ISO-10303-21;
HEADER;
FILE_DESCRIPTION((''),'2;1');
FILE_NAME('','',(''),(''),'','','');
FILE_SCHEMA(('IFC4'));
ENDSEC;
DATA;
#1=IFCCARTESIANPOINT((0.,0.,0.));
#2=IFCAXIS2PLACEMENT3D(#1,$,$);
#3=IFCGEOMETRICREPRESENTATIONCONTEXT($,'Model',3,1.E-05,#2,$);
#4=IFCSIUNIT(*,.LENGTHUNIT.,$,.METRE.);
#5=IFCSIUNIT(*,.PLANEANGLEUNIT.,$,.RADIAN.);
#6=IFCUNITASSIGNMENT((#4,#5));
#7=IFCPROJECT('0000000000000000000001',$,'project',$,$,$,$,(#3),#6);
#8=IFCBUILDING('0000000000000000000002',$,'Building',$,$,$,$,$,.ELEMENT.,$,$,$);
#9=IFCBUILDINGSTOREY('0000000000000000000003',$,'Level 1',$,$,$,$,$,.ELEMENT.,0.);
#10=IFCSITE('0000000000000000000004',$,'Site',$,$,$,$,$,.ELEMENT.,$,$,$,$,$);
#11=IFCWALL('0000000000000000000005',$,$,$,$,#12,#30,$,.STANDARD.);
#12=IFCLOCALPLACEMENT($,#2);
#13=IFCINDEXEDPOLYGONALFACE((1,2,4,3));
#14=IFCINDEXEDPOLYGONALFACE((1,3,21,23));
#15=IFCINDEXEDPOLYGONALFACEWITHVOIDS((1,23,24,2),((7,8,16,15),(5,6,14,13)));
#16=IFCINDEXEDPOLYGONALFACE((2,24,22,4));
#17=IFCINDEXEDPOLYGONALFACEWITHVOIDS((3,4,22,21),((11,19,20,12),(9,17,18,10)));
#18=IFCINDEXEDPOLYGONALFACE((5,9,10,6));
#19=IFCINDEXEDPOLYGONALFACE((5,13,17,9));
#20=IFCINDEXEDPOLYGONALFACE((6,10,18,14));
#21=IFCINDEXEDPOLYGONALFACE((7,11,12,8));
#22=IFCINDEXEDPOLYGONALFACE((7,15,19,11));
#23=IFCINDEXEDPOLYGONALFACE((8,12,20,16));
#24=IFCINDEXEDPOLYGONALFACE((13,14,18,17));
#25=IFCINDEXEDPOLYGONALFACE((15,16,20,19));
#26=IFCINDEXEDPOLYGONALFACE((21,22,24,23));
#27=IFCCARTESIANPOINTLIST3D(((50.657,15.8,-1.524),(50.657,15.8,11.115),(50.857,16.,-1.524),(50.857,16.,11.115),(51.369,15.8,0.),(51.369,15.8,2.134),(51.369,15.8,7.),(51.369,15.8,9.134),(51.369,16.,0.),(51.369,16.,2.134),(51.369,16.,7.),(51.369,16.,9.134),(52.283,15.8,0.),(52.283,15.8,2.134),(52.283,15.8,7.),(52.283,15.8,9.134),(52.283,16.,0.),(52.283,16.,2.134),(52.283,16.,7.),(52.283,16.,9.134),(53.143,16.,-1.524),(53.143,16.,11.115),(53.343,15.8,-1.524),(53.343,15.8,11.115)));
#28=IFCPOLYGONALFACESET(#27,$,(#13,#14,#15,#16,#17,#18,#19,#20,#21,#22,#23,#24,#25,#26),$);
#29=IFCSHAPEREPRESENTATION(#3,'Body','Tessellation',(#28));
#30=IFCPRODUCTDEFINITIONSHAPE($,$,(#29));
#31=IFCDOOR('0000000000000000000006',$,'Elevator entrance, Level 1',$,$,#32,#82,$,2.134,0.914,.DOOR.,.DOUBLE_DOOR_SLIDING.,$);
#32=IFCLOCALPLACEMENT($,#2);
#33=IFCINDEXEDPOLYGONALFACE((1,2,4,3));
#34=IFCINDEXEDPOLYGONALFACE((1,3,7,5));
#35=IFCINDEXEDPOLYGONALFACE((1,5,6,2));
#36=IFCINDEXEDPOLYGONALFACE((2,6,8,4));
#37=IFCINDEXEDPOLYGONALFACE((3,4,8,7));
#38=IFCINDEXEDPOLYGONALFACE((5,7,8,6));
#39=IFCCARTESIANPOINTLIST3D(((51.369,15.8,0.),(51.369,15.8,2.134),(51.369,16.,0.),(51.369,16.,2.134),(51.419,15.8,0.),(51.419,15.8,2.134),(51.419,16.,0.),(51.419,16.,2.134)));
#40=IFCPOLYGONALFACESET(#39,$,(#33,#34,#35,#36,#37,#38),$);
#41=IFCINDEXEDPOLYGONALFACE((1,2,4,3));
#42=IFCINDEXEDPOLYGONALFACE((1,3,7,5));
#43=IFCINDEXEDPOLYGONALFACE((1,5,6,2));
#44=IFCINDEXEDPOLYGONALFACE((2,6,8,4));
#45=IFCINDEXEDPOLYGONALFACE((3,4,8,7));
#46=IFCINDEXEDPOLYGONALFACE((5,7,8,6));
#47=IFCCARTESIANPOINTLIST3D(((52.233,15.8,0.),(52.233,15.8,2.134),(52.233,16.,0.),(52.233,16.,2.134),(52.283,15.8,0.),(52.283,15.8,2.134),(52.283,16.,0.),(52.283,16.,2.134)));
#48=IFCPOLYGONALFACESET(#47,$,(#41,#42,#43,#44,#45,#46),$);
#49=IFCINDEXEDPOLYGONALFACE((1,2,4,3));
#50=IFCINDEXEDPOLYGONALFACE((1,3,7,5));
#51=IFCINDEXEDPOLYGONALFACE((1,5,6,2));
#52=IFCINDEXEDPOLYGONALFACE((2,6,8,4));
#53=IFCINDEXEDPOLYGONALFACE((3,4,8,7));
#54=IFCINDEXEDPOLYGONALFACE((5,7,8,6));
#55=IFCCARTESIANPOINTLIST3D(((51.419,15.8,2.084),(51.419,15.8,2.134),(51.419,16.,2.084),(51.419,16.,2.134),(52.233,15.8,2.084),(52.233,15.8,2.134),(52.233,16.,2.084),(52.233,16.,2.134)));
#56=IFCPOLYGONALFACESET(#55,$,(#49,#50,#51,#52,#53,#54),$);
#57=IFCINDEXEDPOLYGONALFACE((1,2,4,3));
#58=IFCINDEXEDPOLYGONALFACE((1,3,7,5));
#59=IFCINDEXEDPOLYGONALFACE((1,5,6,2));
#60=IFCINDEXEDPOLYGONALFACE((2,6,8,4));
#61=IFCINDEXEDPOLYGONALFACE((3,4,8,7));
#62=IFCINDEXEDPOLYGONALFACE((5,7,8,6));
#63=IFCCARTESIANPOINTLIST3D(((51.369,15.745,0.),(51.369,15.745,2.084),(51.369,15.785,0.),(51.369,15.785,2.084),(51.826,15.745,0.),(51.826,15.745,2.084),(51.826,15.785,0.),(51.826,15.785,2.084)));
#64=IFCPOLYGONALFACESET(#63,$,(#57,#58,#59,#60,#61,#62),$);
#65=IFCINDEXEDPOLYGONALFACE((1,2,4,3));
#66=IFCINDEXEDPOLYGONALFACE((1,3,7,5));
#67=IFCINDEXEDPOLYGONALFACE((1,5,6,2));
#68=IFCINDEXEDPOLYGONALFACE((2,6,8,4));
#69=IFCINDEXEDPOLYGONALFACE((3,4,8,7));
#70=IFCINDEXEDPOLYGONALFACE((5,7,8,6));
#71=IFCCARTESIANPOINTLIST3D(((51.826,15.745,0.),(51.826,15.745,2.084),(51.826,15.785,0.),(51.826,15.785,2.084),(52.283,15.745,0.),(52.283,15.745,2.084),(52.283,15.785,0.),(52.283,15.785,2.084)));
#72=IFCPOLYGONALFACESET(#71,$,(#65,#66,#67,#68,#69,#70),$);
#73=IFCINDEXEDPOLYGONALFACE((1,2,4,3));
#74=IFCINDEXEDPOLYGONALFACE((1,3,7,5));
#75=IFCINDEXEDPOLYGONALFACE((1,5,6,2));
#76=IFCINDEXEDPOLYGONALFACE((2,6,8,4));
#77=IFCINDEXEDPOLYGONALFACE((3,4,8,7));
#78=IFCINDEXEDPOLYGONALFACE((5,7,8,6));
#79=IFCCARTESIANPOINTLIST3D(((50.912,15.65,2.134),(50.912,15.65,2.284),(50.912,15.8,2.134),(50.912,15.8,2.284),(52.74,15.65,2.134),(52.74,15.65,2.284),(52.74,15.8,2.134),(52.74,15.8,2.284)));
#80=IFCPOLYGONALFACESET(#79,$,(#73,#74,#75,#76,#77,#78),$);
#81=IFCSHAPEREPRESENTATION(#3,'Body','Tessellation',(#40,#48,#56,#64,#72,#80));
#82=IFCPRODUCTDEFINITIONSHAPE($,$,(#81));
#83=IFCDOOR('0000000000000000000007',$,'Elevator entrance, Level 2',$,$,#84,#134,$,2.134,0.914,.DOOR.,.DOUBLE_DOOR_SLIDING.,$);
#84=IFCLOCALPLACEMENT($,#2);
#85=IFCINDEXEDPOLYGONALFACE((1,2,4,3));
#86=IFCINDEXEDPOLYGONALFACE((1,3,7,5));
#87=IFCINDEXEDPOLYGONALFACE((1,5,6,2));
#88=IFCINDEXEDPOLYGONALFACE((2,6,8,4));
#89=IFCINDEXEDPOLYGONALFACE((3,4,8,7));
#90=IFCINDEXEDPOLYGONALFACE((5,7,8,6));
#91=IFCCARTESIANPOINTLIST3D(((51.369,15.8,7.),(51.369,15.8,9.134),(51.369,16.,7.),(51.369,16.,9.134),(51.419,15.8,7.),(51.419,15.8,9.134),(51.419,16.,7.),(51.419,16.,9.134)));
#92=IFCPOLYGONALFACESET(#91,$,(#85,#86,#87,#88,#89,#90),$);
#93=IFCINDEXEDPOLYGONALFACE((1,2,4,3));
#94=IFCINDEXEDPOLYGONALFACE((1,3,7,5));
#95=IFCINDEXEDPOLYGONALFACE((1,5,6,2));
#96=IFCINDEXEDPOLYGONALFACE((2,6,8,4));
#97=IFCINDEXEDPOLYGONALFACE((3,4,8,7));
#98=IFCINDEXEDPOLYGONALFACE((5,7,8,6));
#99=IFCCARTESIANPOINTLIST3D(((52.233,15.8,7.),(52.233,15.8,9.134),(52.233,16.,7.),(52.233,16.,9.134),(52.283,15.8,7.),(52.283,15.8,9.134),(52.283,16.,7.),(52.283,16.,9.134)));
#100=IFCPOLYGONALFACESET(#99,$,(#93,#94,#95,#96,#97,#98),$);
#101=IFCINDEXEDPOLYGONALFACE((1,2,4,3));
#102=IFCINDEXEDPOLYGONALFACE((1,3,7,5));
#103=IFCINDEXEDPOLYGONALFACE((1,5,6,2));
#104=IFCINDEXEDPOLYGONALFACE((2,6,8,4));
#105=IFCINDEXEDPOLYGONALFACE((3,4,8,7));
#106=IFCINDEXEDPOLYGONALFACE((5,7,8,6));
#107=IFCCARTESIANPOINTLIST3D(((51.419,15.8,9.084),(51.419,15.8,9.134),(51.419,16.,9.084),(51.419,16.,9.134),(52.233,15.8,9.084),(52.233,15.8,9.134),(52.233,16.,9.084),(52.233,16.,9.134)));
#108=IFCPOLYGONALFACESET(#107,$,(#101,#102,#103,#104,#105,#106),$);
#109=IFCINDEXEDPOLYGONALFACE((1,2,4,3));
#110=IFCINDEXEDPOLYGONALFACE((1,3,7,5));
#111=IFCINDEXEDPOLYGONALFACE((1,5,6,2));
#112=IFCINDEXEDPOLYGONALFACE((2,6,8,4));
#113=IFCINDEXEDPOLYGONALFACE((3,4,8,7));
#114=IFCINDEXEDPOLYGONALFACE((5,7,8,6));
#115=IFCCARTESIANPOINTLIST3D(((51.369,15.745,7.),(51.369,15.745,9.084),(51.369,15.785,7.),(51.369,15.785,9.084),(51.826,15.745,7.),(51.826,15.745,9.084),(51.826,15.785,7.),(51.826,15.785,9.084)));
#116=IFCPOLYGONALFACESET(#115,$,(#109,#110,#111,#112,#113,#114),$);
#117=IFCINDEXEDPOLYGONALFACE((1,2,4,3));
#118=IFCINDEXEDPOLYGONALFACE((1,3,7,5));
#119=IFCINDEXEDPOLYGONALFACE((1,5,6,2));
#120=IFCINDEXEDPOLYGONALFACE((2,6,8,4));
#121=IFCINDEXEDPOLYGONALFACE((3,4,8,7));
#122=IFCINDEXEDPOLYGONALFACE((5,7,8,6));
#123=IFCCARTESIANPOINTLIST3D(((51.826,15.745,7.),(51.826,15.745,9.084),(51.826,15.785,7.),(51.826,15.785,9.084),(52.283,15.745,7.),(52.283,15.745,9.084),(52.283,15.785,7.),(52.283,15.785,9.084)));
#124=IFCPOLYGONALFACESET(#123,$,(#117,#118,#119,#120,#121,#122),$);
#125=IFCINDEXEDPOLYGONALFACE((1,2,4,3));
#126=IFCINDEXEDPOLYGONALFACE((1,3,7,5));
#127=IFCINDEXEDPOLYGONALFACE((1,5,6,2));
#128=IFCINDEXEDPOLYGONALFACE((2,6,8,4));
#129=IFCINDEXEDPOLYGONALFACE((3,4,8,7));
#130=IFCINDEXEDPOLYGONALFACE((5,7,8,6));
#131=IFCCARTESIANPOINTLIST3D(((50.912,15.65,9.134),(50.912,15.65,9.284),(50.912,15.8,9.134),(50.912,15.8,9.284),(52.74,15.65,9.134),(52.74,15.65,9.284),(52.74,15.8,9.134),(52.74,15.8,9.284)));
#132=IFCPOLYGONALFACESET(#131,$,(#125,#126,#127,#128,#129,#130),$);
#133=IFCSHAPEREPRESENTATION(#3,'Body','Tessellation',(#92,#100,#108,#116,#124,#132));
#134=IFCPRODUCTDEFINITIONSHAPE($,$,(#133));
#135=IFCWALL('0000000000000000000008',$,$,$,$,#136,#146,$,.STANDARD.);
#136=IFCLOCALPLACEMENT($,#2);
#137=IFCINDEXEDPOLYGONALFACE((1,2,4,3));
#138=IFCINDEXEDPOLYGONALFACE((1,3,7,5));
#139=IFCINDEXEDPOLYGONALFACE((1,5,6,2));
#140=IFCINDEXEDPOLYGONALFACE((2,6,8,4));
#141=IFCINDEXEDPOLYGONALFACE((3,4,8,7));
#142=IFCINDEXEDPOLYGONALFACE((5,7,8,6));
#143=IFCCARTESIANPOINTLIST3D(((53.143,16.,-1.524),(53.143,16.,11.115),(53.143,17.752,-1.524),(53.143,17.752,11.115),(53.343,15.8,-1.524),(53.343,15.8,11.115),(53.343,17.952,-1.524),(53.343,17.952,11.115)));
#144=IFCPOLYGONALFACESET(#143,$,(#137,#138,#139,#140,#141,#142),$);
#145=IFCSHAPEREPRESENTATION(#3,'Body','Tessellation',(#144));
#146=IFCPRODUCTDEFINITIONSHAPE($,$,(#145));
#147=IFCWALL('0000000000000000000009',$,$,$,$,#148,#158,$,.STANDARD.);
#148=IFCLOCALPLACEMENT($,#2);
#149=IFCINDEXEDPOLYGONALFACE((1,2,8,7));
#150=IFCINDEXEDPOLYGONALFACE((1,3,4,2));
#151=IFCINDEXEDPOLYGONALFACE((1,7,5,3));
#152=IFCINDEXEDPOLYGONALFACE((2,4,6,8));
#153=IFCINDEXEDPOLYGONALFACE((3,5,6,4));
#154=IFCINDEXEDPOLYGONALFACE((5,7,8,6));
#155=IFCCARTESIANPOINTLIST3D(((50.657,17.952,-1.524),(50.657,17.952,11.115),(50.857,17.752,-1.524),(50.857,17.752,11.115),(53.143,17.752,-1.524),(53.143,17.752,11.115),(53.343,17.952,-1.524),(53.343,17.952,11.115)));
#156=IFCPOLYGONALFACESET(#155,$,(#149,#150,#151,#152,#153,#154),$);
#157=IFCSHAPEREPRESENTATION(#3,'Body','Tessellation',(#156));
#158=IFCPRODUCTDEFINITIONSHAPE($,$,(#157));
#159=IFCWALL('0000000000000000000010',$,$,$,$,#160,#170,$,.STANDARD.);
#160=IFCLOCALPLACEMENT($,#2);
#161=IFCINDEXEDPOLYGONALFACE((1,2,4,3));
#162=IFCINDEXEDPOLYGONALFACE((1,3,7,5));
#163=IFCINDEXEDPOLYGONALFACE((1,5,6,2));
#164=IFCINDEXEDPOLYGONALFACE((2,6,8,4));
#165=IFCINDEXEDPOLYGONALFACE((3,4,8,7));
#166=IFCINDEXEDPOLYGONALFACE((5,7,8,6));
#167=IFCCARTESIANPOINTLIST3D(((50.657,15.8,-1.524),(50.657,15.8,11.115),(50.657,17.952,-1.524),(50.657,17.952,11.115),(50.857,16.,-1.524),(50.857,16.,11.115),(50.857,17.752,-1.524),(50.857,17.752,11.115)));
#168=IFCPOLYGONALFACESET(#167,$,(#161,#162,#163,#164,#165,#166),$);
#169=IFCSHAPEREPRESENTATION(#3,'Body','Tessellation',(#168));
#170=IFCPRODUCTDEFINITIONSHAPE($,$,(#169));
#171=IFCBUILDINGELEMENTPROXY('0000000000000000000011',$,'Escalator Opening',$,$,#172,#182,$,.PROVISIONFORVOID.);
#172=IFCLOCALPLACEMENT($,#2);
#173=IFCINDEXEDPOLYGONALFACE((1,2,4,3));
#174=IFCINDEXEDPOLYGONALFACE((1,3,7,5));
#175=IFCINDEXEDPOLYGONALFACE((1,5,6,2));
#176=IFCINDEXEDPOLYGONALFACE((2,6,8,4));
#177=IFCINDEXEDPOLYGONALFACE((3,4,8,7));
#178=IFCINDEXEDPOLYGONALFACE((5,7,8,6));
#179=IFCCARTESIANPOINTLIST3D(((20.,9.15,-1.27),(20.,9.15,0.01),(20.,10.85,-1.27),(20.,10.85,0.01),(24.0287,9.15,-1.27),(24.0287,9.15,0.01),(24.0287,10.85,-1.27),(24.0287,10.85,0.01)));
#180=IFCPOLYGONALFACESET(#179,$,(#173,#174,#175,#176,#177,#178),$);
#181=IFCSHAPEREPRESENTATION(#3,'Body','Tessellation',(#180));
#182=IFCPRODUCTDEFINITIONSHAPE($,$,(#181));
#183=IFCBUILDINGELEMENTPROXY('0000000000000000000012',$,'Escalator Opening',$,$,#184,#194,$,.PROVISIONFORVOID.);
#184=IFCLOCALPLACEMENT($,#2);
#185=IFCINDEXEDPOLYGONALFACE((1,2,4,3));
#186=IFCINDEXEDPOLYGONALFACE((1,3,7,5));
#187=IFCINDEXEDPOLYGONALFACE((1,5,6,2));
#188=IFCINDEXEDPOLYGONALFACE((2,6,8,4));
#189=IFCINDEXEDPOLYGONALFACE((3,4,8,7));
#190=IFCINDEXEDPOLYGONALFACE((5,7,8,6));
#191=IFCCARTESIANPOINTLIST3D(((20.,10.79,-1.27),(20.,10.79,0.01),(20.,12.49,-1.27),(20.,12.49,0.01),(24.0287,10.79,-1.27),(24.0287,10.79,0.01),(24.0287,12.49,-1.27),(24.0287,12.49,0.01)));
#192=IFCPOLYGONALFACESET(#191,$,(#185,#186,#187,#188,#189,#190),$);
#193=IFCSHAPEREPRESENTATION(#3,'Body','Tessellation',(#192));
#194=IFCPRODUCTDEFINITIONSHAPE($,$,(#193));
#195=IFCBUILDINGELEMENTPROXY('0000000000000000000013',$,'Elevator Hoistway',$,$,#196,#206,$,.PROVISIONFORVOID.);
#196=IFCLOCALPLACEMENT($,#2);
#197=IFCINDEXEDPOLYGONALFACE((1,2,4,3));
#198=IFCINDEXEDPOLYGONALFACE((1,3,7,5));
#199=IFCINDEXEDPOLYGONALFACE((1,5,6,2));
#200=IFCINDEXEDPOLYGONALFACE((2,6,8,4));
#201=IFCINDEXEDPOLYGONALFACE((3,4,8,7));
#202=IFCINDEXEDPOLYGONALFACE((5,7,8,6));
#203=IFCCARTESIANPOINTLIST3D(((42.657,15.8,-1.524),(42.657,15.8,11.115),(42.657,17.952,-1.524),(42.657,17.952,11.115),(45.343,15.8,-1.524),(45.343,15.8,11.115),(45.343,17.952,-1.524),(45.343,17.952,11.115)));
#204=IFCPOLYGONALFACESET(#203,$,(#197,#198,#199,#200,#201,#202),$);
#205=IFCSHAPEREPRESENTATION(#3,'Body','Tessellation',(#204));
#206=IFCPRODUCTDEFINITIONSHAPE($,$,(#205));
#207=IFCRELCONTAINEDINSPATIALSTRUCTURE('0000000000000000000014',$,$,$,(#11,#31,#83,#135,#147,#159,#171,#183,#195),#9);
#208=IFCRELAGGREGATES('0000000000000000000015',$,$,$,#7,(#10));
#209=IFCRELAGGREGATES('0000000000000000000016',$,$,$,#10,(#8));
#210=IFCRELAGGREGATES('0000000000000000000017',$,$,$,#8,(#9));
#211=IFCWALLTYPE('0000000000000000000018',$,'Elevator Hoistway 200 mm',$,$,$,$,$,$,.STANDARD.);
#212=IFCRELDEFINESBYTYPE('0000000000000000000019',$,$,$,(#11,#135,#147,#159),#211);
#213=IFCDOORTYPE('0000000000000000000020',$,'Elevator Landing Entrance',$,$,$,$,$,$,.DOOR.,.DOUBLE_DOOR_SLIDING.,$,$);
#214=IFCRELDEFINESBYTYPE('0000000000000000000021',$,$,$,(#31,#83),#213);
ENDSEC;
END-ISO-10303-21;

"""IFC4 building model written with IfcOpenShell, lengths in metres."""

from ifc_helpers import new_model, si_unit, frame, frame_2d, origin, origin_with_axes, origin_2d, place, context, project, spatial, polyline, rectangle, outline, extrude, type_object, element, fill, save


model = new_model("IFC4")

# Units and contexts
model_context = context("Model", 3, precision=1e-05, world=origin())
ifc_project = project(units=[si_unit("LENGTHUNIT", "METRE"), si_unit("PLANEANGLEUNIT", "RADIAN")], contexts=[model_context])

# Site, building, storey
site = spatial("IfcSite", under=ifc_project, Name="Site", CompositionType="ELEMENT")
building = spatial("IfcBuilding", under=site, Name="Building", CompositionType="ELEMENT")
storey = spatial("IfcBuildingStorey", under=building, Name="Level 1", CompositionType="ELEMENT", Elevation=0.0)

# Shared definitions
wall_type = type_object("IfcWallType", Name="Elevator Hoistway 200 mm", PredefinedType="STANDARD")
door_type = type_object("IfcDoorType", Name="Elevator Landing Entrance", OperationType="DOUBLE_DOOR_SLIDING", PredefinedType="DOOR")

# Wall, openings, doors
wall_1_placement = place(None, frame((50.757, 15.9, -1.524), z_axis=(0.0, 0.0, 1.0), x_axis=(1.0, 0.0, 0.0)))
wall_1 = element("IfcWall", 1, at=wall_1_placement, inside=storey, type_object=wall_type, PredefinedType="STANDARD", context=model_context, shape_type="SweptSolid", body=[
    extrude(outline(polyline([(-0.1, -0.1), (2.586, -0.1), (2.386, 0.1), (0.1, 0.1), (-0.1, -0.1)])), origin(), (0.0, 0.0, 1.0), 12.639),
])
opening_1_placement = place(wall_1_placement, frame((1.069, 0.0, 1.524), z_axis=(0.0, 0.0, 1.0), x_axis=(1.0, 0.0, 0.0)))
opening_1 = element("IfcOpeningElement", 2, at=opening_1_placement, cuts=wall_1, PredefinedType="OPENING", context=model_context, shape_type="SweptSolid", body=[
    extrude(rectangle(XDim=0.914, YDim=0.202, at=origin_2d()), origin(), (0.0, 0.0, 1.0), 2.134),
])
opening_2_placement = place(wall_1_placement, frame((1.069, 0.0, 8.524), z_axis=(0.0, 0.0, 1.0), x_axis=(1.0, 0.0, 0.0)))
opening_2 = element("IfcOpeningElement", 3, at=opening_2_placement, cuts=wall_1, PredefinedType="OPENING", context=model_context, shape_type="SweptSolid", body=[
    extrude(rectangle(XDim=0.914, YDim=0.202, at=origin_2d()), origin(), (0.0, 0.0, 1.0), 2.134),
])
door_1_placement = place(opening_1_placement, origin_with_axes())
door_1 = element("IfcDoor", 4, at=door_1_placement, inside=storey, type_object=door_type, Name="Elevator entrance, Level 1", OperationType="DOUBLE_DOOR_SLIDING", OverallHeight=2.134, OverallWidth=0.914, PredefinedType="DOOR", context=model_context, shape_type="SweptSolid", body=[
    extrude(rectangle(XDim=0.05, YDim=0.2, at=frame_2d((-0.432, 0.0))), origin(), (0.0, 0.0, 1.0), 2.134),
    extrude(rectangle(XDim=0.05, YDim=0.2, at=frame_2d((0.432, 0.0))), origin(), (0.0, 0.0, 1.0), 2.134),
    extrude(rectangle(XDim=0.814, YDim=0.2, at=origin_2d()), frame((0.0, 0.0, 2.084)), (0.0, 0.0, 1.0), 0.05),
    extrude(rectangle(XDim=0.457, YDim=0.04, at=frame_2d((-0.2285, -0.135))), origin(), (0.0, 0.0, 1.0), 2.084),
    extrude(rectangle(XDim=0.457, YDim=0.04, at=frame_2d((0.2285, -0.135))), origin(), (0.0, 0.0, 1.0), 2.084),
    extrude(rectangle(XDim=1.828, YDim=0.15, at=frame_2d((0.0, -0.175))), frame((0.0, 0.0, 2.134)), (0.0, 0.0, 1.0), 0.15),
])
fill(opening_1, door_1)
door_2_placement = place(opening_2_placement, origin_with_axes())
door_2 = element("IfcDoor", 5, at=door_2_placement, inside=storey, type_object=door_type, Name="Elevator entrance, Level 2", OperationType="DOUBLE_DOOR_SLIDING", OverallHeight=2.134, OverallWidth=0.914, PredefinedType="DOOR", context=model_context, shape_type="SweptSolid", body=[
    extrude(rectangle(XDim=0.05, YDim=0.2, at=frame_2d((-0.432, 0.0))), origin(), (0.0, 0.0, 1.0), 2.134),
    extrude(rectangle(XDim=0.05, YDim=0.2, at=frame_2d((0.432, 0.0))), origin(), (0.0, 0.0, 1.0), 2.134),
    extrude(rectangle(XDim=0.814, YDim=0.2, at=origin_2d()), frame((0.0, 0.0, 2.084)), (0.0, 0.0, 1.0), 0.05),
    extrude(rectangle(XDim=0.457, YDim=0.04, at=frame_2d((-0.2285, -0.135))), origin(), (0.0, 0.0, 1.0), 2.084),
    extrude(rectangle(XDim=0.457, YDim=0.04, at=frame_2d((0.2285, -0.135))), origin(), (0.0, 0.0, 1.0), 2.084),
    extrude(rectangle(XDim=1.828, YDim=0.15, at=frame_2d((0.0, -0.175))), frame((0.0, 0.0, 2.134)), (0.0, 0.0, 1.0), 0.15),
])
fill(opening_2, door_2)

# Walls
wall_2_placement = place(None, frame((53.243, 15.9, -1.524), z_axis=(0.0, 0.0, 1.0), x_axis=(0.0, 1.0, 0.0)))
element("IfcWall", 6, at=wall_2_placement, inside=storey, type_object=wall_type, PredefinedType="STANDARD", context=model_context, shape_type="SweptSolid", body=[
    extrude(outline(polyline([(-0.1, -0.1), (2.052, -0.1), (1.852, 0.1), (0.1, 0.1), (-0.1, -0.1)])), origin(), (0.0, 0.0, 1.0), 12.639),
])
wall_3_placement = place(None, frame((53.243, 17.852, -1.524), z_axis=(0.0, 0.0, 1.0), x_axis=(-1.0, 0.0, 0.0)))
element("IfcWall", 7, at=wall_3_placement, inside=storey, type_object=wall_type, PredefinedType="STANDARD", context=model_context, shape_type="SweptSolid", body=[
    extrude(outline(polyline([(-0.1, -0.1), (2.586, -0.1), (2.386, 0.1), (0.1, 0.1), (-0.1, -0.1)])), origin(), (0.0, 0.0, 1.0), 12.639),
])
wall_4_placement = place(None, frame((50.757, 17.852, -1.524), z_axis=(0.0, 0.0, 1.0), x_axis=(0.0, -1.0, 0.0)))
element("IfcWall", 8, at=wall_4_placement, inside=storey, type_object=wall_type, PredefinedType="STANDARD", context=model_context, shape_type="SweptSolid", body=[
    extrude(outline(polyline([(-0.1, -0.1), (2.052, -0.1), (1.852, 0.1), (0.1, 0.1), (-0.1, -0.1)])), origin(), (0.0, 0.0, 1.0), 12.639),
])

# Building element proxies
proxy_1_placement = place(None, frame((0.0, 0.0, 0.01)))
element("IfcBuildingElementProxy", 9, at=proxy_1_placement, inside=storey, Name="Escalator Opening", PredefinedType="PROVISIONFORVOID", context=model_context, shape_type="SweptSolid", body=[
    extrude(outline(polyline([(20.0, 9.15), (24.0287, 9.15), (24.0287, 10.85), (20.0, 10.85), (20.0, 9.15)])), origin(), (0.0, 0.0, -1.0), 1.28),
])
proxy_2_placement = place(None, frame((0.0, 0.0, 0.01)))
element("IfcBuildingElementProxy", 10, at=proxy_2_placement, inside=storey, Name="Escalator Opening", PredefinedType="PROVISIONFORVOID", context=model_context, shape_type="SweptSolid", body=[
    extrude(outline(polyline([(20.0, 10.79), (24.0287, 10.79), (24.0287, 12.49), (20.0, 12.49), (20.0, 10.79)])), origin(), (0.0, 0.0, -1.0), 1.28),
])
proxy_3_placement = place(None, frame((0.0, 0.0, 11.115)))
element("IfcBuildingElementProxy", 11, at=proxy_3_placement, inside=storey, Name="Elevator Hoistway", PredefinedType="PROVISIONFORVOID", context=model_context, shape_type="SweptSolid", body=[
    extrude(outline(polyline([(42.657, 15.8), (45.343, 15.8), (45.343, 17.952), (42.657, 17.952), (42.657, 15.8)])), origin(), (0.0, 0.0, -1.0), 12.639),
])

save(model, "model.ifc")
